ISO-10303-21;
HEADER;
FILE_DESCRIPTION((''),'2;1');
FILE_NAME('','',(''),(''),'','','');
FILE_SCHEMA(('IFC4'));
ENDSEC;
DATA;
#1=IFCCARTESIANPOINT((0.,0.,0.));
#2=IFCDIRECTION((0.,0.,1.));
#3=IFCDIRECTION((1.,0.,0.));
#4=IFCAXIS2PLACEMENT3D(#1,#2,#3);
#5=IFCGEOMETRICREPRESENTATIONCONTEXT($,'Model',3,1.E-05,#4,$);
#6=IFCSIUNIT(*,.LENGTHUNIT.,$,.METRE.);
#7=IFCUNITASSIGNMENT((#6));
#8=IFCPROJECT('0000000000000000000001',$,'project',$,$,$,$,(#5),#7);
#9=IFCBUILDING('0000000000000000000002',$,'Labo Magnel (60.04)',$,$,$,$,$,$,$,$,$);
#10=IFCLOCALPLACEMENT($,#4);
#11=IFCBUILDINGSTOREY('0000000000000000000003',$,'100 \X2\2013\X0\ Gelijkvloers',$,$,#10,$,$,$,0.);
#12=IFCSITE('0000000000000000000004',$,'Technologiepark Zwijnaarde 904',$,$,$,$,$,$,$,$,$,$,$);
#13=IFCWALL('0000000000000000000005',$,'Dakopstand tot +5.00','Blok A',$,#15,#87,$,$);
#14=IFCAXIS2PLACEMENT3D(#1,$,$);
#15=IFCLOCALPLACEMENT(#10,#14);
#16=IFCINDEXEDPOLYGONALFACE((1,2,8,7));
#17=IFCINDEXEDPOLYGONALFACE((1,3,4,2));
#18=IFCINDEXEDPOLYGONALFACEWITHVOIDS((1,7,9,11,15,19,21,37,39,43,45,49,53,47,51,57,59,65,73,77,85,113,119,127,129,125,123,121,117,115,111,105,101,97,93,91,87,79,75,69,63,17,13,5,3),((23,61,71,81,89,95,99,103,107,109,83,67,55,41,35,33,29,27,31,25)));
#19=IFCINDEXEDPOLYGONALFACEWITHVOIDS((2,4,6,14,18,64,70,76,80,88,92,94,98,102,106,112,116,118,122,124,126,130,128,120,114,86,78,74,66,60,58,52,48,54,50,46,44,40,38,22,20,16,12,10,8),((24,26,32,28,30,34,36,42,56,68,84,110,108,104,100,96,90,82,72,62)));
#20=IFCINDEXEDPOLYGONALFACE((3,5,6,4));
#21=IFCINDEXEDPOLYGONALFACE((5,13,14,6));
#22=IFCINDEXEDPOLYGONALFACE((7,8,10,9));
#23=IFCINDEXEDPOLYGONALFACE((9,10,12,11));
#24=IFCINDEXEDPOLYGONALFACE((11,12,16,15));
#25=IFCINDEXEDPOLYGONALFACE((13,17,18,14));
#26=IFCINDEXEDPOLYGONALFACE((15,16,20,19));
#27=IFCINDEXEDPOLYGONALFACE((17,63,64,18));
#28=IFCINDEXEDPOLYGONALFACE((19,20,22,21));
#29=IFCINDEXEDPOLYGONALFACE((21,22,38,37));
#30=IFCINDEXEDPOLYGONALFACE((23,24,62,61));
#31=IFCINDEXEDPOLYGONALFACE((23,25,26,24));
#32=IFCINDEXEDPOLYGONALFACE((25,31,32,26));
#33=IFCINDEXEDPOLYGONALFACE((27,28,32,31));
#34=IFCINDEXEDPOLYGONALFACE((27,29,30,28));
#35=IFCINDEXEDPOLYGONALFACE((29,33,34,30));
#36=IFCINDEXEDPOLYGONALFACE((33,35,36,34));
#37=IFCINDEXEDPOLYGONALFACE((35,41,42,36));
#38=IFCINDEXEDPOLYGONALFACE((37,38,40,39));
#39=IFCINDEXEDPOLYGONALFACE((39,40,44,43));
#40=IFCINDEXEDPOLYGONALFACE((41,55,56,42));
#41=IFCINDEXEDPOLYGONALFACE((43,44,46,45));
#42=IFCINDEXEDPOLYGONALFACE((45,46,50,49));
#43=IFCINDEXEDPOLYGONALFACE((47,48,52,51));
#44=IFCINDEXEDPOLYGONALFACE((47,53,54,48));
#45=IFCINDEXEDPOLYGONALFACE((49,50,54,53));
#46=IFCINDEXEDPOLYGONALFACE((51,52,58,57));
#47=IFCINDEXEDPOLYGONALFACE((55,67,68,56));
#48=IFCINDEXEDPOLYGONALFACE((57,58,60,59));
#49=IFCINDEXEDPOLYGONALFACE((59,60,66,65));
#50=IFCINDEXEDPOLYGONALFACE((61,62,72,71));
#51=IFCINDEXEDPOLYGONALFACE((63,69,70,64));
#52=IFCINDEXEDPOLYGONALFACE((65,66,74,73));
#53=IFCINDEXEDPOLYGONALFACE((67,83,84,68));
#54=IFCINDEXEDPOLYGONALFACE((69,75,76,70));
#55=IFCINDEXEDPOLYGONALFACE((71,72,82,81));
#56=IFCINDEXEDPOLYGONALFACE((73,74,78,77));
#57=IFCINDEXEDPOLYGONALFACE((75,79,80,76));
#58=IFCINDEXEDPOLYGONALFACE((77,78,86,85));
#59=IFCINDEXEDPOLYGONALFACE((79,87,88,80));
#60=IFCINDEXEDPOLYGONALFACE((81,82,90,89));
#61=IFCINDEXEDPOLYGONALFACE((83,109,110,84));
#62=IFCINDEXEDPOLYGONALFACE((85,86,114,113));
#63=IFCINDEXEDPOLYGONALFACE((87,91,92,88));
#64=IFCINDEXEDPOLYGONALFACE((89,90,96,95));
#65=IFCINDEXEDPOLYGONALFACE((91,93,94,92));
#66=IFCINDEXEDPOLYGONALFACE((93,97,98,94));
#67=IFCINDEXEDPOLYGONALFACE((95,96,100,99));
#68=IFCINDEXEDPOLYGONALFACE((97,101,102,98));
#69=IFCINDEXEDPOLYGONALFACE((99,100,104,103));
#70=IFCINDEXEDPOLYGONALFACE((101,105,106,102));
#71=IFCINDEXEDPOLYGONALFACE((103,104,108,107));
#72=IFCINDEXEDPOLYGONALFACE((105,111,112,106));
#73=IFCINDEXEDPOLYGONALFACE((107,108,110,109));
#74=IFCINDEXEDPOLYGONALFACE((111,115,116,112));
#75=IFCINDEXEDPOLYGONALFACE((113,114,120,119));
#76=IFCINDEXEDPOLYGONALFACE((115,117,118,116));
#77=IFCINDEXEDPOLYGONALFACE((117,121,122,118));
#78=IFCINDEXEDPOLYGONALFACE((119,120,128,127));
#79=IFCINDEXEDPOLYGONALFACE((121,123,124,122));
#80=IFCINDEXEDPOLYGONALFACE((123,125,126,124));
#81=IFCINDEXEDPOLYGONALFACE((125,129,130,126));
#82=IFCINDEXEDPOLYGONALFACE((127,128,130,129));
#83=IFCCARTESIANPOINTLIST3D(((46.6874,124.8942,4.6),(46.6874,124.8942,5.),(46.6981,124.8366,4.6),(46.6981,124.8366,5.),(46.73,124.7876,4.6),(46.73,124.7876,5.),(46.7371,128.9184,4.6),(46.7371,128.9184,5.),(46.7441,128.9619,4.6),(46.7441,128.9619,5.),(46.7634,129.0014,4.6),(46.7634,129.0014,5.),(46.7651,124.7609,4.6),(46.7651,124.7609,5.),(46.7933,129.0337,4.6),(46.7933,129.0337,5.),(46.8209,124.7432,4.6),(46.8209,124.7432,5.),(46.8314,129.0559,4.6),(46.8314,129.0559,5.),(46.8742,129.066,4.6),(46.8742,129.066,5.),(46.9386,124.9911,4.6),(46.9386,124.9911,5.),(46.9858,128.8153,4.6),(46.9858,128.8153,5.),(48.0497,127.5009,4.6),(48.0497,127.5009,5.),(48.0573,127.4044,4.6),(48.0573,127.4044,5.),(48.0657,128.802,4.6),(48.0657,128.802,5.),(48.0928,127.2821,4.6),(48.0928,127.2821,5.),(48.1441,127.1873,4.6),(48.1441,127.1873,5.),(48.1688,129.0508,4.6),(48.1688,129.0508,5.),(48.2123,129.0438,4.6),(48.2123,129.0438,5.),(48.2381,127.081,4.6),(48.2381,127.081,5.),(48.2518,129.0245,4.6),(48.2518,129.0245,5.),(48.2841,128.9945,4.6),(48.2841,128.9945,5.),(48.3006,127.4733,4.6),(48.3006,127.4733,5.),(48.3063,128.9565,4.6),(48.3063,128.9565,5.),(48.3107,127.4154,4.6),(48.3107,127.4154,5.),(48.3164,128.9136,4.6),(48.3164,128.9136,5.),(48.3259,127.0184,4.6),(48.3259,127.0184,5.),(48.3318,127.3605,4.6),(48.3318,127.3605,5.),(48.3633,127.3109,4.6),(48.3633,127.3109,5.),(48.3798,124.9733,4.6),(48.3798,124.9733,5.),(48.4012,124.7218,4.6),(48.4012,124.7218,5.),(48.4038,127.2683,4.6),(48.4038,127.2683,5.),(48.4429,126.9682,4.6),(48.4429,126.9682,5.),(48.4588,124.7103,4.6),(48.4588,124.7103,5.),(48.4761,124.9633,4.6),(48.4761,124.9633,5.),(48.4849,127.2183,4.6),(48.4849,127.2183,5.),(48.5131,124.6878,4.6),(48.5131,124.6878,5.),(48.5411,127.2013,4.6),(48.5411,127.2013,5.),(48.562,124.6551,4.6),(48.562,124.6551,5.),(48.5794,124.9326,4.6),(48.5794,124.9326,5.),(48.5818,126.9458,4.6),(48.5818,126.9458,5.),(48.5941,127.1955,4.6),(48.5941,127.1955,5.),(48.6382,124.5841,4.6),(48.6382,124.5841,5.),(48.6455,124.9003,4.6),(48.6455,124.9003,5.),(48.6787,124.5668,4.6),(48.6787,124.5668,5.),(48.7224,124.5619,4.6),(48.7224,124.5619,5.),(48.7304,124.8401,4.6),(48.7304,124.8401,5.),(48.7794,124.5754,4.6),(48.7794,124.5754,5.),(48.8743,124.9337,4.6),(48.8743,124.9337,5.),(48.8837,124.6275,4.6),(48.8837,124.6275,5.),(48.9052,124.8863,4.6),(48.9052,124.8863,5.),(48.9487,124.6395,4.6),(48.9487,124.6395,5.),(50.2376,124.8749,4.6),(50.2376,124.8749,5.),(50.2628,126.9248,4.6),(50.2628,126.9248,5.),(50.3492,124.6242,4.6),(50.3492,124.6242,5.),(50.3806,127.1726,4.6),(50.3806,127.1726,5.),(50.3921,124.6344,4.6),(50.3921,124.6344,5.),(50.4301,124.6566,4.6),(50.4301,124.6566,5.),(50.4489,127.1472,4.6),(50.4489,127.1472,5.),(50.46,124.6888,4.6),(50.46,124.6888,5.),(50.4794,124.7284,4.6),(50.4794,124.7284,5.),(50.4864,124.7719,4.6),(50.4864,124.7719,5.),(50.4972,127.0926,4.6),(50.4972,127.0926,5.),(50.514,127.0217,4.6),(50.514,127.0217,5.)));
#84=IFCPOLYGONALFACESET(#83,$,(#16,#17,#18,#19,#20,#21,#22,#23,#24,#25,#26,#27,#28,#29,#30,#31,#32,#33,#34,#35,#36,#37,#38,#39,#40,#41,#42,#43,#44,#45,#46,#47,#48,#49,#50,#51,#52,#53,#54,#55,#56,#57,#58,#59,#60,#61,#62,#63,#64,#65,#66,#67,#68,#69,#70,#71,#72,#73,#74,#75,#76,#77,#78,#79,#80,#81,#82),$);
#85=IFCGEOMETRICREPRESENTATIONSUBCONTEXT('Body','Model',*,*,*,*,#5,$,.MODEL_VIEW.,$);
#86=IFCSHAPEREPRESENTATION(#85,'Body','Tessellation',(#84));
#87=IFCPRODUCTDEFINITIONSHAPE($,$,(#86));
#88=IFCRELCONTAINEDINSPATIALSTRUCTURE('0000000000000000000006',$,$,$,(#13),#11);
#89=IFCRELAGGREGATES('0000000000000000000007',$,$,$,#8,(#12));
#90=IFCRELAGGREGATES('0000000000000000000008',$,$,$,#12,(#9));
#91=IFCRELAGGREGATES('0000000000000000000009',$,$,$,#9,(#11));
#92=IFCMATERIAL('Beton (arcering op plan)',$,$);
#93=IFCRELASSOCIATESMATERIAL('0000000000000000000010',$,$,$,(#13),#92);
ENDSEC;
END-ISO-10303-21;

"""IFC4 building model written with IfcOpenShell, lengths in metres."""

from ifc_helpers import new_model, si_unit, frame, origin, origin_with_axes, place, context, subcontext, project, spatial, polyline, outline, extrude, material, element, save


model = new_model("IFC4")

# Units and contexts
model_context = context("Model", 3, precision=1e-05, world=origin_with_axes())
body_context = subcontext(model_context, "Body", "Model", "MODEL_VIEW")
ifc_project = project(units=[si_unit("LENGTHUNIT", "METRE")], contexts=[model_context])

# Site, building, storey
site = spatial("IfcSite", under=ifc_project, Name="Technologiepark Zwijnaarde 904")
building = spatial("IfcBuilding", under=site, Name="Labo Magnel (60.04)")
storey_placement = place(None, origin_with_axes())
storey = spatial("IfcBuildingStorey", under=building, at=storey_placement, Name="100 – Gelijkvloers", Elevation=0.0)

# Shared definitions
ifc_material_1 = material(Name="Beton (arcering op plan)")

# Wall
wall_1_placement = place(storey_placement, frame((0.0, 0.0, 4.6), z_axis=(0.0, 0.0, 1.0), x_axis=(1.0, 0.0, 0.0)))
element("IfcWall", 1, at=wall_1_placement, inside=storey, material=ifc_material_1, Name="Dakopstand tot +5.00", Description="Blok A", context=body_context, shape_type="SweptSolid", body=[
    extrude(outline(polyline([(46.8209, 124.7432), (46.7651, 124.7609), (46.73, 124.7876), (46.6981, 124.8366), (46.6874, 124.8942), (46.7371, 128.9184), (46.7441, 128.9619), (46.7634, 129.0014), (46.7933, 129.0337), (46.8314, 129.0559), (46.8742, 129.066), (48.1688, 129.0508), (48.2123, 129.0438), (48.2518, 129.0245), (48.2841, 128.9945), (48.3063, 128.9565), (48.3164, 128.9136), (48.3006, 127.4733), (48.3107, 127.4154), (48.3318, 127.3605), (48.3633, 127.3109), (48.4038, 127.2683), (48.4849, 127.2183), (48.5411, 127.2013), (48.5941, 127.1955), (50.3806, 127.1726), (50.4489, 127.1472), (50.4972, 127.0926), (50.514, 127.0217), (50.4864, 124.7719), (50.4794, 124.7284), (50.46, 124.6888), (50.4301, 124.6566), (50.3921, 124.6344), (50.3492, 124.6242), (48.9487, 124.6395), (48.8837, 124.6275), (48.7794, 124.5754), (48.7224, 124.5619), (48.6787, 124.5668), (48.6382, 124.5841), (48.562, 124.6551), (48.5131, 124.6878), (48.4588, 124.7103), (48.4012, 124.7218), (46.8209, 124.7432)]), holes=[polyline([(48.3798, 124.9733), (48.4761, 124.9633), (48.5794, 124.9326), (48.6455, 124.9003), (48.7304, 124.8401), (48.8743, 124.9337), (48.9052, 124.8863), (50.2376, 124.8749), (50.2628, 126.9248), (48.5818, 126.9458), (48.4429, 126.9682), (48.3259, 127.0184), (48.2381, 127.081), (48.1441, 127.1873), (48.0928, 127.2821), (48.0573, 127.4044), (48.0497, 127.5009), (48.0657, 128.802), (46.9858, 128.8153), (46.9386, 124.9911), (48.3798, 124.9733)])]), origin(), (0.0, 0.0, 1.0), 0.4),
])

save(model, "model.ifc")
